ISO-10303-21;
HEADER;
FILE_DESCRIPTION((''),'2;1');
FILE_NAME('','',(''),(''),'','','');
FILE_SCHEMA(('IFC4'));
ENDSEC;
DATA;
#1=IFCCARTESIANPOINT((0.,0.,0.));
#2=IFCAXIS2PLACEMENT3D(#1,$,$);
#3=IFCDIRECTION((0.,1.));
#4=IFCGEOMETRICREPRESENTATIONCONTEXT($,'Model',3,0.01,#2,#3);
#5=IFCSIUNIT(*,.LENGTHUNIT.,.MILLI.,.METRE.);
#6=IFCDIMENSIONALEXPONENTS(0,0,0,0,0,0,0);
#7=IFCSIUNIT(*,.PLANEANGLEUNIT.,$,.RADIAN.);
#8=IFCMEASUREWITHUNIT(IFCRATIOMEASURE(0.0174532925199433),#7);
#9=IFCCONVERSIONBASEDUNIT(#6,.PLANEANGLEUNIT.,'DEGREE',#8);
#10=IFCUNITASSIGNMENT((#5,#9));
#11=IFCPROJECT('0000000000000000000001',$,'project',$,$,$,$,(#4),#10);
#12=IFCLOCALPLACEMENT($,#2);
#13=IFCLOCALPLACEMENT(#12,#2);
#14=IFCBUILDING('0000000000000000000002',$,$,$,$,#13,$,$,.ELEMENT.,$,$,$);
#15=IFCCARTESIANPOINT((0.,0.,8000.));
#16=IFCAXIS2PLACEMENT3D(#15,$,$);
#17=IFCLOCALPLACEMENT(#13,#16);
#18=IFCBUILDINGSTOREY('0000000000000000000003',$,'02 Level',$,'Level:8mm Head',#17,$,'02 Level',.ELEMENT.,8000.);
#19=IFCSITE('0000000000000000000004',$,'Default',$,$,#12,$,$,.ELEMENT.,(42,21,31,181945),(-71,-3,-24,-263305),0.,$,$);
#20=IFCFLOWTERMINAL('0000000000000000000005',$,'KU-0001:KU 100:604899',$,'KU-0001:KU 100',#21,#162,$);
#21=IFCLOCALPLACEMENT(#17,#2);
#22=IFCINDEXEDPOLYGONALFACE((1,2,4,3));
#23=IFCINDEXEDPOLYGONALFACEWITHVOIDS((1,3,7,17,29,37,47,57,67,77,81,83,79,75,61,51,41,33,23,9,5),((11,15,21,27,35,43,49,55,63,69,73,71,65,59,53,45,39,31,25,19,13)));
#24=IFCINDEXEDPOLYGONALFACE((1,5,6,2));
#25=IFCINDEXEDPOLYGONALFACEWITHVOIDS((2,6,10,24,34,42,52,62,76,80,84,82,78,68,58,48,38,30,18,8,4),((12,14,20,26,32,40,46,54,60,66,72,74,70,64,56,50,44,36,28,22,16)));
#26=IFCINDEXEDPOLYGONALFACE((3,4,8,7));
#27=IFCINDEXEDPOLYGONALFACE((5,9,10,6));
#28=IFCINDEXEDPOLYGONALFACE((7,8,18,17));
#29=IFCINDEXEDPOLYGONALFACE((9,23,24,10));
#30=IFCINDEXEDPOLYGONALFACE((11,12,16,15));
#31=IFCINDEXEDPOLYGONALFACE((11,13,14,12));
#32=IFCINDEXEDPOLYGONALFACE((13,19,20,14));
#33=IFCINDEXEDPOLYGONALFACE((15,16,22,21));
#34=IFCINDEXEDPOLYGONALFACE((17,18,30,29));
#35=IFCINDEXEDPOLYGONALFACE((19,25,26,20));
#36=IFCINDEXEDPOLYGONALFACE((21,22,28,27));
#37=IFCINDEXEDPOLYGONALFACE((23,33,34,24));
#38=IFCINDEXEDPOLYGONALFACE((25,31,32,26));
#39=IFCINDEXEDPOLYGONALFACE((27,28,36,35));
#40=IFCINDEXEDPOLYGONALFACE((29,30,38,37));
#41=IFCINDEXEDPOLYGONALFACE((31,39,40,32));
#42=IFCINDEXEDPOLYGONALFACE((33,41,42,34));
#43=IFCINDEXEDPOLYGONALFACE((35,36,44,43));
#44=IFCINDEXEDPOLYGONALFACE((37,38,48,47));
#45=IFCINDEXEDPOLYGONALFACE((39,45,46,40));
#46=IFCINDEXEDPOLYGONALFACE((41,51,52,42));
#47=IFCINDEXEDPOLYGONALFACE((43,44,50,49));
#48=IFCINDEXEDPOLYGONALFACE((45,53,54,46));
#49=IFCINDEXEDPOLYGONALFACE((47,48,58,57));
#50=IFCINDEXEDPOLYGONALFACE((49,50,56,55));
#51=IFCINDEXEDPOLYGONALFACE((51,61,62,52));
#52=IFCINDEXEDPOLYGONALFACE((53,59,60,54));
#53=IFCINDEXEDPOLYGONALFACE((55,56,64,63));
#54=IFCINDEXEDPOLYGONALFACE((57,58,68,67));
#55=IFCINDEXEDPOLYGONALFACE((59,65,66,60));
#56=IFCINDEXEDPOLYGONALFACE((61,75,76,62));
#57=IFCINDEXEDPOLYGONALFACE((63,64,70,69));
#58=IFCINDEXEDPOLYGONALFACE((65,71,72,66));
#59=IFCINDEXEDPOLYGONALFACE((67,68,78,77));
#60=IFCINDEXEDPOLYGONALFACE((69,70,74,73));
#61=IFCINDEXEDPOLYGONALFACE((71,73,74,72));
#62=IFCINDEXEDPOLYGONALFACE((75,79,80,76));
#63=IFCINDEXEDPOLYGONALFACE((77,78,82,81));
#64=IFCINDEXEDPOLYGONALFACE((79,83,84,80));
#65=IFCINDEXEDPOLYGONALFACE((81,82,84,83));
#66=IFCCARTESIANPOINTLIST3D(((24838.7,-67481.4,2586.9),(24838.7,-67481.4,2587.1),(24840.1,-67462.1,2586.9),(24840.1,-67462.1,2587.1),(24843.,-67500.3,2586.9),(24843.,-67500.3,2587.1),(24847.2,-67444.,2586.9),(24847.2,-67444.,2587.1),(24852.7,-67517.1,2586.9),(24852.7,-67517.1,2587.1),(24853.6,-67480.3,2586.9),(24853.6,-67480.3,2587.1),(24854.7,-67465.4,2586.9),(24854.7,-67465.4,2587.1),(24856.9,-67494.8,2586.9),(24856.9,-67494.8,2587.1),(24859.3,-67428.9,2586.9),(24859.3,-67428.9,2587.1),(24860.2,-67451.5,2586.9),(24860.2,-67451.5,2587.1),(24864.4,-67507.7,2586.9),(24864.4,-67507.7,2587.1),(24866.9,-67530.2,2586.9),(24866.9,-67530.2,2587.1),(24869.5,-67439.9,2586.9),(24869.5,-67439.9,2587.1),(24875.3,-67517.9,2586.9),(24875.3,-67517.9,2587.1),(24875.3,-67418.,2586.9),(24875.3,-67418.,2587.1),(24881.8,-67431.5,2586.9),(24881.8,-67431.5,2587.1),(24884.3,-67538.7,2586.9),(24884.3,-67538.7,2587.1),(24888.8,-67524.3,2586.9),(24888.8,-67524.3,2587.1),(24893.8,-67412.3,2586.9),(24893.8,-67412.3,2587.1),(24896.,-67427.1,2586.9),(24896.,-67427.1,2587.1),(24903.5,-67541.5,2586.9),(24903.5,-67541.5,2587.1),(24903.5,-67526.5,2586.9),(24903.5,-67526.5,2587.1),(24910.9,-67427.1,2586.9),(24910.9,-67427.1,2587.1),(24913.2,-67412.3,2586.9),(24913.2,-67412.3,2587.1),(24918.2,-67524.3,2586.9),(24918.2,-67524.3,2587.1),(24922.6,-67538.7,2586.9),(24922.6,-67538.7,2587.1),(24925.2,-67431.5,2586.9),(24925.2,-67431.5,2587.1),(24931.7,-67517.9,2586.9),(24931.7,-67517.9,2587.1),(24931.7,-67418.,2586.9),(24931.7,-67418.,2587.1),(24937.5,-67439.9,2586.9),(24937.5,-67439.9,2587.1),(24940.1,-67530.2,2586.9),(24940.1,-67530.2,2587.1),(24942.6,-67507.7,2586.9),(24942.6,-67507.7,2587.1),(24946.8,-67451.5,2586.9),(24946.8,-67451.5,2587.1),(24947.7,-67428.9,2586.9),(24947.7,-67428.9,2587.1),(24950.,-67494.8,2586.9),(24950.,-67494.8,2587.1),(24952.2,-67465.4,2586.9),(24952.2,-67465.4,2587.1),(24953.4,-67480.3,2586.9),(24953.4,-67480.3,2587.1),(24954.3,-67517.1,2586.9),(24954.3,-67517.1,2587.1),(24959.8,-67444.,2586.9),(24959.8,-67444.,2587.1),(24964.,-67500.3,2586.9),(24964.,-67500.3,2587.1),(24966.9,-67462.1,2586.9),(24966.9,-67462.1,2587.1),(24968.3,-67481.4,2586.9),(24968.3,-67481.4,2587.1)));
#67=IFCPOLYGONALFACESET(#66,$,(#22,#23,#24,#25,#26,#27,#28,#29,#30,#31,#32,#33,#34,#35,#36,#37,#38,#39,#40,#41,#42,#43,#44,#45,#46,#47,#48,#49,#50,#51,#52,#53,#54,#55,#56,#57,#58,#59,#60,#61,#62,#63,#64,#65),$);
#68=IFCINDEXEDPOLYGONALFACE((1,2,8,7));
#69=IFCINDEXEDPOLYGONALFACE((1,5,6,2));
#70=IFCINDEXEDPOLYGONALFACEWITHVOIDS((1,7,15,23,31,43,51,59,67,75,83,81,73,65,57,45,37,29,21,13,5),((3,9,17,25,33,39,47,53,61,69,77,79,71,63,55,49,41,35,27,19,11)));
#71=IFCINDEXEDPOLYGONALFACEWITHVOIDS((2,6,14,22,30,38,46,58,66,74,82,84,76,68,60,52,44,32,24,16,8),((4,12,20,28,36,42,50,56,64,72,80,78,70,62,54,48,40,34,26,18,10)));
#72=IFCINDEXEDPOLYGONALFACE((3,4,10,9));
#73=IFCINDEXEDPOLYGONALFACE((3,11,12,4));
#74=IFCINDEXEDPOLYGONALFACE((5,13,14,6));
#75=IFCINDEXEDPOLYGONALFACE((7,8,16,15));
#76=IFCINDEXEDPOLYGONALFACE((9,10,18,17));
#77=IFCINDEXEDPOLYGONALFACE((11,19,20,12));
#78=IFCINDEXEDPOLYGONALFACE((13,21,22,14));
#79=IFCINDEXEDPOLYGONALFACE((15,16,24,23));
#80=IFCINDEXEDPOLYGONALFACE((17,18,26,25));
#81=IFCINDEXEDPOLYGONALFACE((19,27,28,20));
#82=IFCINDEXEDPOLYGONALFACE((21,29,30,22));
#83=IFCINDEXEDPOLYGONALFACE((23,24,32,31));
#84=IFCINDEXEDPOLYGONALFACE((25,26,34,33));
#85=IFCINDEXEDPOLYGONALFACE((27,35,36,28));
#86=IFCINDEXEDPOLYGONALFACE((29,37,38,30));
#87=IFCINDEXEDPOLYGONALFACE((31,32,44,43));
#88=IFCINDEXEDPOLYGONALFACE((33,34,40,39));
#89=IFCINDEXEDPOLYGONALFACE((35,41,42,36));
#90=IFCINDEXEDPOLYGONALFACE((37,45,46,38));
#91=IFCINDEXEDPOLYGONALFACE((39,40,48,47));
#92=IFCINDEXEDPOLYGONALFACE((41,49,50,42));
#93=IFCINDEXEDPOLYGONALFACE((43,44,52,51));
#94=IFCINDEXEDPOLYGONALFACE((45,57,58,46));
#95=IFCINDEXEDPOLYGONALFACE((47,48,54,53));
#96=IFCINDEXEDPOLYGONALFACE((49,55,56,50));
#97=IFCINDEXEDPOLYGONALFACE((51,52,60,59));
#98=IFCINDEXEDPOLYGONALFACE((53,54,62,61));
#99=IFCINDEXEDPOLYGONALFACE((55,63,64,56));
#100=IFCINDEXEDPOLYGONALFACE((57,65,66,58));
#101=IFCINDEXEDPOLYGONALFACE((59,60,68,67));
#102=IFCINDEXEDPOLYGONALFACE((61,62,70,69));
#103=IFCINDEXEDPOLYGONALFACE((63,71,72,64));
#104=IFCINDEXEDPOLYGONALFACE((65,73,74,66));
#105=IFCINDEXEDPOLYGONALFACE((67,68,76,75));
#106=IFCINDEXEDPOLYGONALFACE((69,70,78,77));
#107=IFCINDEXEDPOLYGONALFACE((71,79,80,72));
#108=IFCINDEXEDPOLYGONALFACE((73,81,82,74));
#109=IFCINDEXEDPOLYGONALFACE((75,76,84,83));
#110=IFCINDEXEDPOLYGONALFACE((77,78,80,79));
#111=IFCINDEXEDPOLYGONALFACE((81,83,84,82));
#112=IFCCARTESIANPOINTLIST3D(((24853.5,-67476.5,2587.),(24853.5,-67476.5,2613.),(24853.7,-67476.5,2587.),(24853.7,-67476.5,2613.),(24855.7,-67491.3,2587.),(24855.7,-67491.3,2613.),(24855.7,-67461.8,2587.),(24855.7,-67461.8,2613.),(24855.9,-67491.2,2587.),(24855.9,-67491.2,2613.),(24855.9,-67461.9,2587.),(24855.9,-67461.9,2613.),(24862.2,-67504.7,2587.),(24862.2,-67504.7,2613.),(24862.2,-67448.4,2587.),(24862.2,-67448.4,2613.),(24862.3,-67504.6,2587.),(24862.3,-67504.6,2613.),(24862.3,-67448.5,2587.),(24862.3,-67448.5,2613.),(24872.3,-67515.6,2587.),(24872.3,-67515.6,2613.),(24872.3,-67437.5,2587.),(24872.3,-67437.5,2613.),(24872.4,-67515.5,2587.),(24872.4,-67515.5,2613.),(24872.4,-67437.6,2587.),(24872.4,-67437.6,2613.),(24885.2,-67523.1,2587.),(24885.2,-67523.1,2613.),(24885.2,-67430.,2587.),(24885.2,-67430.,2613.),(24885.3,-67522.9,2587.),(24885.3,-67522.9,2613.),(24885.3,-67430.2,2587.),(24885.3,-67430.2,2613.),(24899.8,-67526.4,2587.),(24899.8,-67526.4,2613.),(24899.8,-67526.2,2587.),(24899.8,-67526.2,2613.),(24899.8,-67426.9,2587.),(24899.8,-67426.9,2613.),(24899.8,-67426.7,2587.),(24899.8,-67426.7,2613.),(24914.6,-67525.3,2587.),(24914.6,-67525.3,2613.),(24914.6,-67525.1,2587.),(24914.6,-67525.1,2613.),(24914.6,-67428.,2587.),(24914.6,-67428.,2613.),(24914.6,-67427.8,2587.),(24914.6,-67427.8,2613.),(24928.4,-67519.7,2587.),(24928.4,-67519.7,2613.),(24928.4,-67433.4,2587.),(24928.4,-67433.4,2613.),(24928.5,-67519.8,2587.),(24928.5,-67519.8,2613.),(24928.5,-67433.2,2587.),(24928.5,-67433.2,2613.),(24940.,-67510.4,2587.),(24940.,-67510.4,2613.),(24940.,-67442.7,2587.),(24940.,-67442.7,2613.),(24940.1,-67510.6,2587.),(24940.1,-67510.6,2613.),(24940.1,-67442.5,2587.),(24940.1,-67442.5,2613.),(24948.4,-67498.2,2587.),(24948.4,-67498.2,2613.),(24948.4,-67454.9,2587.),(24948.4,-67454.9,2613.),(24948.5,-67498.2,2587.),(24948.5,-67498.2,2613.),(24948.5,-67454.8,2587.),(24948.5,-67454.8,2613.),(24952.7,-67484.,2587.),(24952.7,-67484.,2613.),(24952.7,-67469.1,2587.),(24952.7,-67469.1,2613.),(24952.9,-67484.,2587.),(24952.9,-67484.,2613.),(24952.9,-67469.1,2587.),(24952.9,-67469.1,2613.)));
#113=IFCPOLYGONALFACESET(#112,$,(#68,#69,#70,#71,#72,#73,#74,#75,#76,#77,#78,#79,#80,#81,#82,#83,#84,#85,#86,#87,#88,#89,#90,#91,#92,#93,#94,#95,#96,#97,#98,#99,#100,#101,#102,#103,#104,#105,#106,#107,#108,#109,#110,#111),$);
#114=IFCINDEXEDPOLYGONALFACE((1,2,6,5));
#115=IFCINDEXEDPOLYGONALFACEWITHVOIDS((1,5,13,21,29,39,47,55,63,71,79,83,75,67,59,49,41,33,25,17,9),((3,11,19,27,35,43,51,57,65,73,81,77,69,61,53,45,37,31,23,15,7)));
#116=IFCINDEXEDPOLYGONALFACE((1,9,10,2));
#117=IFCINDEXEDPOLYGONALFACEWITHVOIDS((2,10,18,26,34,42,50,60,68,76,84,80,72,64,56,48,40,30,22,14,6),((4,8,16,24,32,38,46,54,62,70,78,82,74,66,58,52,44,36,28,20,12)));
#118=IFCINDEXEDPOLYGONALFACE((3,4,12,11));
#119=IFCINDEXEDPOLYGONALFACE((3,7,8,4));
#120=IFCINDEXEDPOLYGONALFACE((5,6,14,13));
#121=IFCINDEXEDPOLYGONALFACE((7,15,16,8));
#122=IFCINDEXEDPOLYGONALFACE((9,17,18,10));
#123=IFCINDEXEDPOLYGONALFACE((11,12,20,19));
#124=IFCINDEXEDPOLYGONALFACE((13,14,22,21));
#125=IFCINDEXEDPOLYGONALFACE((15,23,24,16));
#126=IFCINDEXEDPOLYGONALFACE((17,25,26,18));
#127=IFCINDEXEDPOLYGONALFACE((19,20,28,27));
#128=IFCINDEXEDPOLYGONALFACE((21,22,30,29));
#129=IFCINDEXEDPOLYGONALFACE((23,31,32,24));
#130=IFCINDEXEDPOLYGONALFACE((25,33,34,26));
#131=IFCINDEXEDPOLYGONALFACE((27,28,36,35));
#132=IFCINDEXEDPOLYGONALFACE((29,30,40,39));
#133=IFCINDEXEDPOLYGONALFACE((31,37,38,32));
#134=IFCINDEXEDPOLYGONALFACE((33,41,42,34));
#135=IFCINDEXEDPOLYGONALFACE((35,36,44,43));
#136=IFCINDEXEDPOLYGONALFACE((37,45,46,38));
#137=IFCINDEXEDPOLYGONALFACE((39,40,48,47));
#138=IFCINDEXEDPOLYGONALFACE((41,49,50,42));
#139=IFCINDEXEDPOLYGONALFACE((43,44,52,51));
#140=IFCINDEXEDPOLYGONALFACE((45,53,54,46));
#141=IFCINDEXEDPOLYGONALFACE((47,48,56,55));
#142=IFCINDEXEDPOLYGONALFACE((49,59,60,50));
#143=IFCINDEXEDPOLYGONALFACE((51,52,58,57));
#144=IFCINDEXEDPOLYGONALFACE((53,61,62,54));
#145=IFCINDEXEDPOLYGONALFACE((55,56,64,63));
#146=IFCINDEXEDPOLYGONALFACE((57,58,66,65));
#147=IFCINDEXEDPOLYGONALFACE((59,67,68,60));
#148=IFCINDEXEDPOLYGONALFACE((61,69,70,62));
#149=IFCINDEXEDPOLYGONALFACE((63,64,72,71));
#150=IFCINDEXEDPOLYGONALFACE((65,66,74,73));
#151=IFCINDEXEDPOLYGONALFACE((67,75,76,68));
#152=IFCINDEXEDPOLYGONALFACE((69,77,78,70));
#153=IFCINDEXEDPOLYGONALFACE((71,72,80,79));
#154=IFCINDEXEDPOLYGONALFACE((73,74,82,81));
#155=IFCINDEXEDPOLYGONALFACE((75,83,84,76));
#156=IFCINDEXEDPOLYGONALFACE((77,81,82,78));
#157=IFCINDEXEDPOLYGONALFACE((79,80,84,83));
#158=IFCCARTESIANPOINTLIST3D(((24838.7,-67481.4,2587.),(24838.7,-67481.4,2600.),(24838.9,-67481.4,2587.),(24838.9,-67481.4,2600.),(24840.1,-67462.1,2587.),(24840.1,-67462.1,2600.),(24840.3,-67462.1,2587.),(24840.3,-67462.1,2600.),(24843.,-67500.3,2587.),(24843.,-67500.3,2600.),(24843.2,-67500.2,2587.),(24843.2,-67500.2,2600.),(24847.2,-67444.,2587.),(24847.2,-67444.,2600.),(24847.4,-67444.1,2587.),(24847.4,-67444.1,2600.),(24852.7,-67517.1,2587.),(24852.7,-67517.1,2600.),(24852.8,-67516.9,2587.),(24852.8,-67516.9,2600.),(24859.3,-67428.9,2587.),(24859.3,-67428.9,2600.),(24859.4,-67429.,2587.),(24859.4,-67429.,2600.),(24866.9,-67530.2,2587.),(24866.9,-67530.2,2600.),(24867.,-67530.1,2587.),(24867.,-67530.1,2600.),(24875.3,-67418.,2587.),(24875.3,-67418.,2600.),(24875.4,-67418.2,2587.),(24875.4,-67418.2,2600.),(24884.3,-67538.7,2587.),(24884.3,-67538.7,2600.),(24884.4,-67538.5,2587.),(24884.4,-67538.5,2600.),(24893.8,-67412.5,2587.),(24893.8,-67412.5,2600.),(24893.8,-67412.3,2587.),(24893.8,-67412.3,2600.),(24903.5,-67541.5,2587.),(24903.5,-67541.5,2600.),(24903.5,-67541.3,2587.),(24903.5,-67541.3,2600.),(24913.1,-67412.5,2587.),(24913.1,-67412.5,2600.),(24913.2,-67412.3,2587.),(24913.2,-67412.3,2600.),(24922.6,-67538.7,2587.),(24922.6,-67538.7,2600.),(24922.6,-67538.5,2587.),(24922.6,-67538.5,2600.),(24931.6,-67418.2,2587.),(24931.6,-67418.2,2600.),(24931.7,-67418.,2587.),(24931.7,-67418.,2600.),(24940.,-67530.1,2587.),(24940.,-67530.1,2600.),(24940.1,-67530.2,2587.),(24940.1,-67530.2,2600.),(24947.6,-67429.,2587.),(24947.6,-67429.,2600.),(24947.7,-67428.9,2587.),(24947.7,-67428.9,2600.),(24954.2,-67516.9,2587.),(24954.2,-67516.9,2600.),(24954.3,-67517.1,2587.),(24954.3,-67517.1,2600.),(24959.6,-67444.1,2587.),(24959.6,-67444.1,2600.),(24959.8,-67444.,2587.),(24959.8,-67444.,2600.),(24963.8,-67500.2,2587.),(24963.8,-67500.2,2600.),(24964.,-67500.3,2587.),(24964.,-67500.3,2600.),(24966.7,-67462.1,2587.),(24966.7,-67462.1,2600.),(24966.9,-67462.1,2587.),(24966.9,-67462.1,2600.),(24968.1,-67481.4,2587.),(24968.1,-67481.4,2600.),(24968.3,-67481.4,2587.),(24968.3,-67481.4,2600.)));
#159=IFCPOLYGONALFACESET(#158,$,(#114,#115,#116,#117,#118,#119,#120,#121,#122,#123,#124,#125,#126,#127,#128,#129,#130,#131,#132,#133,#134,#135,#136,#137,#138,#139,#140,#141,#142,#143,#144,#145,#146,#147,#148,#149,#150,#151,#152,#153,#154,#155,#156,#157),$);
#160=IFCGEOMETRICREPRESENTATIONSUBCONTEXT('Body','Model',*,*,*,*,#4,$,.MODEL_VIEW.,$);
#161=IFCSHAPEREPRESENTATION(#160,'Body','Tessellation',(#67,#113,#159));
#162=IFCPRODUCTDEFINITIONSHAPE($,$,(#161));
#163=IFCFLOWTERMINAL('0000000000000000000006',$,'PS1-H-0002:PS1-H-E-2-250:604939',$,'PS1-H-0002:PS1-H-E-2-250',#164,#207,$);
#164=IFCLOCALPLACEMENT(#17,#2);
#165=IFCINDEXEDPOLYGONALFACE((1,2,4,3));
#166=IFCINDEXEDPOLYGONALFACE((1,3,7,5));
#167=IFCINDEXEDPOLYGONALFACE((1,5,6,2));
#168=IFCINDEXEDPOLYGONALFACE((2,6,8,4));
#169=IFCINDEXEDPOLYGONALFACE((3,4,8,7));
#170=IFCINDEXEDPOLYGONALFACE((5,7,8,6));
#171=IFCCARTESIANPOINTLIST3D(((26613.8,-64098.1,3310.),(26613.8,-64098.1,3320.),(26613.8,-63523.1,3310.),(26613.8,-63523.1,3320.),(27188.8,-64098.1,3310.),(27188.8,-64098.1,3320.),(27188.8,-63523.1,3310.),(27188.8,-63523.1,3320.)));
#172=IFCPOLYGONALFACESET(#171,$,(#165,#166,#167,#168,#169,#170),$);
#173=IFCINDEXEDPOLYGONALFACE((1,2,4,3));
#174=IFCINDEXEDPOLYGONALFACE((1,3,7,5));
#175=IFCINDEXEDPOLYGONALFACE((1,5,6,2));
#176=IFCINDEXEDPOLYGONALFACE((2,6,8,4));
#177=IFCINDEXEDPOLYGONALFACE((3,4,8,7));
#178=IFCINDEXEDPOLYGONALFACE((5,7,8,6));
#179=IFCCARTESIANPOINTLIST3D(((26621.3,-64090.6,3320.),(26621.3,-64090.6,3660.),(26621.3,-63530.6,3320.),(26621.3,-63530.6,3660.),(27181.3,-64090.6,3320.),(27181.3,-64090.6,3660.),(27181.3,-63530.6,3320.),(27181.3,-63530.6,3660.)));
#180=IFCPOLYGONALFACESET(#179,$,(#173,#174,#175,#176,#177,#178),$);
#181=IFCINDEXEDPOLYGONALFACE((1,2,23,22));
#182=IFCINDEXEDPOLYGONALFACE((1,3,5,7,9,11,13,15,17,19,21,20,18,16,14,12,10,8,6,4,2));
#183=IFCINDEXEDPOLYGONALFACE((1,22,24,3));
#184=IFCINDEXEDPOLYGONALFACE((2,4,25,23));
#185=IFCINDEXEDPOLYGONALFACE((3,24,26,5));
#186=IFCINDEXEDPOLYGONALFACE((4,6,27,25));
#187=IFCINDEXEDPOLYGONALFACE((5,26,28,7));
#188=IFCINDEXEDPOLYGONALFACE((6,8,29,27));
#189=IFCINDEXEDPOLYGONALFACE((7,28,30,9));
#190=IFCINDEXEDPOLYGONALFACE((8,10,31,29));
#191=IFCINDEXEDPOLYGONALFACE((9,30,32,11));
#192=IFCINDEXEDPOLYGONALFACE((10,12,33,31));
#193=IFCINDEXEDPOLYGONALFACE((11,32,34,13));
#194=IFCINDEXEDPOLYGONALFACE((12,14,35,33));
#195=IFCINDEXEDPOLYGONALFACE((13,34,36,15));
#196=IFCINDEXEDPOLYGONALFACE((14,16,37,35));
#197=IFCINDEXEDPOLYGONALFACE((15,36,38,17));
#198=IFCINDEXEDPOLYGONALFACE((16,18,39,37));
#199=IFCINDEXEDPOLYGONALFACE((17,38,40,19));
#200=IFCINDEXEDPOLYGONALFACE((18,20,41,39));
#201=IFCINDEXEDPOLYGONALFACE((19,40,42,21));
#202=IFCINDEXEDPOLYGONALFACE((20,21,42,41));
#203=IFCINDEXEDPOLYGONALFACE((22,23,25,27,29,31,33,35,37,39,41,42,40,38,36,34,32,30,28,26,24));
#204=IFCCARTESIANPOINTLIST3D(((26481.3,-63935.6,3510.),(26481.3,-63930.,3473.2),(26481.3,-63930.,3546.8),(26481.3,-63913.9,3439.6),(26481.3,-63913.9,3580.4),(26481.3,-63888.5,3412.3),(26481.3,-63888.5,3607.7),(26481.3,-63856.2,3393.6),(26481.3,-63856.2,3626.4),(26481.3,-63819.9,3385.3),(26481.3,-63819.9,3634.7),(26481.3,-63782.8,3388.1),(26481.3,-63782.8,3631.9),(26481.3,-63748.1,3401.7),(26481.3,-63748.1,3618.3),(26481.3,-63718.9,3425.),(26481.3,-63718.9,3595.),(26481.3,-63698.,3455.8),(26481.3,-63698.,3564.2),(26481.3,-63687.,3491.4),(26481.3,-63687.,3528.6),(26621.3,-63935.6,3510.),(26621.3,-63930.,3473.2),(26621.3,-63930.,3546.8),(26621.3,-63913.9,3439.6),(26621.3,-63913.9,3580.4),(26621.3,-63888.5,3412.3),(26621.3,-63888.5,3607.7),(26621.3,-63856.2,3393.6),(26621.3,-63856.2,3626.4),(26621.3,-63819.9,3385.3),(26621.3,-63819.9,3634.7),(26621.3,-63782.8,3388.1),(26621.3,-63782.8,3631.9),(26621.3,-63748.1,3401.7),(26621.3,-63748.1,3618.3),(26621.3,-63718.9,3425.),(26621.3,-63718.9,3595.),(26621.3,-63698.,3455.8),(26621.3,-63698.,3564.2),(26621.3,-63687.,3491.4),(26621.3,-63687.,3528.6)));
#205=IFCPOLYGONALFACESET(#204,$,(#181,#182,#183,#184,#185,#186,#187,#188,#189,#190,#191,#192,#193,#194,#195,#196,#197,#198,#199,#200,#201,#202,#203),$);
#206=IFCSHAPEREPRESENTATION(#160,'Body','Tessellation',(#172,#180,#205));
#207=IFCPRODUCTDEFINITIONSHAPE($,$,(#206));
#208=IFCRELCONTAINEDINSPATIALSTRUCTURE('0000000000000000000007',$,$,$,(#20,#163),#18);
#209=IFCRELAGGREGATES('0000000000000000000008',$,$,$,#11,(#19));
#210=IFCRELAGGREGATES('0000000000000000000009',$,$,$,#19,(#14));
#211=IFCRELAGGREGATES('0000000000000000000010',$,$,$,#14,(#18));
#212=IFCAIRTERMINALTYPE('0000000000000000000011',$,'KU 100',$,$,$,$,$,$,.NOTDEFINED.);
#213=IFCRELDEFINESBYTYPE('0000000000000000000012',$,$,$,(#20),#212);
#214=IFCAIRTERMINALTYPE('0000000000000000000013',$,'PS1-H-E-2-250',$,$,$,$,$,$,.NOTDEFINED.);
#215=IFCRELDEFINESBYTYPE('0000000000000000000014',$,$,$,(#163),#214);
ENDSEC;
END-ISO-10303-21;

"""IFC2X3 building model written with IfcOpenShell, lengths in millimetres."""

from ifc_helpers import new_model, entity, si_unit, converted_unit, direction, frame, frame_2d, origin, origin_2d_with_axis, place, context, subcontext, project, spatial, rectangle, circle, hollow_circle, extrude, source, transform, mapped, type_object, type_shapes, element, save


model = new_model("IFC2X3")

# Units and contexts
model_context = context("Model", 3, precision=0.01, world=origin(), true_north=direction((0.0, 1.0)))
body_context = subcontext(model_context, "Body", "Model", "MODEL_VIEW")
ifc_project = project(units=[si_unit("LENGTHUNIT", "METRE", prefix="MILLI"), converted_unit("PLANEANGLEUNIT", "DEGREE", entity("IfcRatioMeasure", 0.0174532925199433), si_unit("PLANEANGLEUNIT", "RADIAN"), dimensions=[0, 0, 0, 0, 0, 0, 0])], contexts=[model_context])

# Site, building, storey
site_placement = place(None, origin())
site = spatial("IfcSite", under=ifc_project, at=site_placement, Name="Default", CompositionType="ELEMENT", RefLatitude=(42, 21, 31, 181945), RefLongitude=(-71, -3, -24, -263305), RefElevation=0.0)
building_placement = place(site_placement, origin())
building = spatial("IfcBuilding", under=site, at=building_placement, CompositionType="ELEMENT")
storey_placement = place(building_placement, frame((0.0, 0.0, 8000.0)))
storey = spatial("IfcBuildingStorey", under=building, at=storey_placement, Name="02 Level", ObjectType="Level:8mm Head", LongName="02 Level", CompositionType="ELEMENT", Elevation=8000.0)

# Flow terminals
air_terminal_type_1 = type_object("IfcAirTerminalType", Name="KU 100", PredefinedType="NOTDEFINED")
shared_shape_1 = source(origin(), body_context, "Body", "SweptSolid", [
    extrude(hollow_circle(Radius=65.0, WallThickness=15.0, at=frame_2d((0.0, 0.0), x_axis=(1.0, 0.0))), frame((12.9, 0.0, 0.0), z_axis=(1.0, 0.0, 0.0), x_axis=(0.0, -1.0, 0.0)), (0.0, 0.0, 1.0), 0.2),
    extrude(hollow_circle(Radius=50.0, WallThickness=0.2, at=frame_2d((0.0, 0.0), x_axis=(1.0, 0.0))), frame((-13.0, 0.0, 0.0), z_axis=(1.0, 0.0, 0.0), x_axis=(0.0, 0.0, -1.0)), (0.0, 0.0, 1.0), 26.0),
    extrude(hollow_circle(Radius=65.0, WallThickness=0.2, at=frame_2d((0.0, 0.0), x_axis=(1.0, 0.0))), frame((0.0, 0.0, 0.0), z_axis=(1.0, 0.0, 0.0), x_axis=(0.0, -1.0, 0.0)), (0.0, 0.0, 1.0), 13.0),
])
type_shapes(air_terminal_type_1, [shared_shape_1])
flow_terminal_1_placement = place(storey_placement, frame((24903.5, -67476.5, 2600.0), z_axis=(1.0, 0.0, 0.0), x_axis=(0.0, 0.0, -1.0)))
element("IfcFlowTerminal", 1, at=flow_terminal_1_placement, inside=storey, type_object=air_terminal_type_1, Name="KU-0001:KU 100:604899", ObjectType="KU-0001:KU 100", context=body_context, shape_type="MappedRepresentation", body=[
    mapped(shared_shape_1, transform((0.0, 0.0, 0.0), scale=1.0)),
])
air_terminal_type_2 = type_object("IfcAirTerminalType", Name="PS1-H-E-2-250", PredefinedType="NOTDEFINED")
shared_shape_2 = source(origin(), body_context, "Body", "SweptSolid", [
    extrude(rectangle(XDim=575.0, YDim=575.0, at=origin_2d_with_axis()), frame((0.0, 0.0, -10.0), z_axis=(0.0, 0.0, 1.0), x_axis=(0.0, 1.0, 0.0)), (0.0, 0.0, 1.0), 10.0),
    extrude(rectangle(XDim=560.0, YDim=560.0, at=origin_2d_with_axis()), frame((0.0, 0.0, 0.0), z_axis=(0.0, 0.0, 1.0), x_axis=(0.0, 1.0, 0.0)), (0.0, 0.0, 1.0), 340.0),
    extrude(circle(Radius=125.0, at=frame_2d((0.0, 0.0), x_axis=(1.0, 0.0))), frame((-420.0, 0.0, 190.0), z_axis=(1.0, 0.0, 0.0), x_axis=(0.0, -1.0, 0.0)), (0.0, 0.0, 1.0), 140.0),
])
type_shapes(air_terminal_type_2, [shared_shape_2])
flow_terminal_2_placement = place(storey_placement, frame((26901.3, -63810.6, 3320.0)))
element("IfcFlowTerminal", 2, at=flow_terminal_2_placement, inside=storey, type_object=air_terminal_type_2, Name="PS1-H-0002:PS1-H-E-2-250:604939", ObjectType="PS1-H-0002:PS1-H-E-2-250", context=body_context, shape_type="MappedRepresentation", body=[
    mapped(shared_shape_2, transform((0.0, 0.0, 0.0), scale=1.0)),
])

save(model, "model.ifc")
